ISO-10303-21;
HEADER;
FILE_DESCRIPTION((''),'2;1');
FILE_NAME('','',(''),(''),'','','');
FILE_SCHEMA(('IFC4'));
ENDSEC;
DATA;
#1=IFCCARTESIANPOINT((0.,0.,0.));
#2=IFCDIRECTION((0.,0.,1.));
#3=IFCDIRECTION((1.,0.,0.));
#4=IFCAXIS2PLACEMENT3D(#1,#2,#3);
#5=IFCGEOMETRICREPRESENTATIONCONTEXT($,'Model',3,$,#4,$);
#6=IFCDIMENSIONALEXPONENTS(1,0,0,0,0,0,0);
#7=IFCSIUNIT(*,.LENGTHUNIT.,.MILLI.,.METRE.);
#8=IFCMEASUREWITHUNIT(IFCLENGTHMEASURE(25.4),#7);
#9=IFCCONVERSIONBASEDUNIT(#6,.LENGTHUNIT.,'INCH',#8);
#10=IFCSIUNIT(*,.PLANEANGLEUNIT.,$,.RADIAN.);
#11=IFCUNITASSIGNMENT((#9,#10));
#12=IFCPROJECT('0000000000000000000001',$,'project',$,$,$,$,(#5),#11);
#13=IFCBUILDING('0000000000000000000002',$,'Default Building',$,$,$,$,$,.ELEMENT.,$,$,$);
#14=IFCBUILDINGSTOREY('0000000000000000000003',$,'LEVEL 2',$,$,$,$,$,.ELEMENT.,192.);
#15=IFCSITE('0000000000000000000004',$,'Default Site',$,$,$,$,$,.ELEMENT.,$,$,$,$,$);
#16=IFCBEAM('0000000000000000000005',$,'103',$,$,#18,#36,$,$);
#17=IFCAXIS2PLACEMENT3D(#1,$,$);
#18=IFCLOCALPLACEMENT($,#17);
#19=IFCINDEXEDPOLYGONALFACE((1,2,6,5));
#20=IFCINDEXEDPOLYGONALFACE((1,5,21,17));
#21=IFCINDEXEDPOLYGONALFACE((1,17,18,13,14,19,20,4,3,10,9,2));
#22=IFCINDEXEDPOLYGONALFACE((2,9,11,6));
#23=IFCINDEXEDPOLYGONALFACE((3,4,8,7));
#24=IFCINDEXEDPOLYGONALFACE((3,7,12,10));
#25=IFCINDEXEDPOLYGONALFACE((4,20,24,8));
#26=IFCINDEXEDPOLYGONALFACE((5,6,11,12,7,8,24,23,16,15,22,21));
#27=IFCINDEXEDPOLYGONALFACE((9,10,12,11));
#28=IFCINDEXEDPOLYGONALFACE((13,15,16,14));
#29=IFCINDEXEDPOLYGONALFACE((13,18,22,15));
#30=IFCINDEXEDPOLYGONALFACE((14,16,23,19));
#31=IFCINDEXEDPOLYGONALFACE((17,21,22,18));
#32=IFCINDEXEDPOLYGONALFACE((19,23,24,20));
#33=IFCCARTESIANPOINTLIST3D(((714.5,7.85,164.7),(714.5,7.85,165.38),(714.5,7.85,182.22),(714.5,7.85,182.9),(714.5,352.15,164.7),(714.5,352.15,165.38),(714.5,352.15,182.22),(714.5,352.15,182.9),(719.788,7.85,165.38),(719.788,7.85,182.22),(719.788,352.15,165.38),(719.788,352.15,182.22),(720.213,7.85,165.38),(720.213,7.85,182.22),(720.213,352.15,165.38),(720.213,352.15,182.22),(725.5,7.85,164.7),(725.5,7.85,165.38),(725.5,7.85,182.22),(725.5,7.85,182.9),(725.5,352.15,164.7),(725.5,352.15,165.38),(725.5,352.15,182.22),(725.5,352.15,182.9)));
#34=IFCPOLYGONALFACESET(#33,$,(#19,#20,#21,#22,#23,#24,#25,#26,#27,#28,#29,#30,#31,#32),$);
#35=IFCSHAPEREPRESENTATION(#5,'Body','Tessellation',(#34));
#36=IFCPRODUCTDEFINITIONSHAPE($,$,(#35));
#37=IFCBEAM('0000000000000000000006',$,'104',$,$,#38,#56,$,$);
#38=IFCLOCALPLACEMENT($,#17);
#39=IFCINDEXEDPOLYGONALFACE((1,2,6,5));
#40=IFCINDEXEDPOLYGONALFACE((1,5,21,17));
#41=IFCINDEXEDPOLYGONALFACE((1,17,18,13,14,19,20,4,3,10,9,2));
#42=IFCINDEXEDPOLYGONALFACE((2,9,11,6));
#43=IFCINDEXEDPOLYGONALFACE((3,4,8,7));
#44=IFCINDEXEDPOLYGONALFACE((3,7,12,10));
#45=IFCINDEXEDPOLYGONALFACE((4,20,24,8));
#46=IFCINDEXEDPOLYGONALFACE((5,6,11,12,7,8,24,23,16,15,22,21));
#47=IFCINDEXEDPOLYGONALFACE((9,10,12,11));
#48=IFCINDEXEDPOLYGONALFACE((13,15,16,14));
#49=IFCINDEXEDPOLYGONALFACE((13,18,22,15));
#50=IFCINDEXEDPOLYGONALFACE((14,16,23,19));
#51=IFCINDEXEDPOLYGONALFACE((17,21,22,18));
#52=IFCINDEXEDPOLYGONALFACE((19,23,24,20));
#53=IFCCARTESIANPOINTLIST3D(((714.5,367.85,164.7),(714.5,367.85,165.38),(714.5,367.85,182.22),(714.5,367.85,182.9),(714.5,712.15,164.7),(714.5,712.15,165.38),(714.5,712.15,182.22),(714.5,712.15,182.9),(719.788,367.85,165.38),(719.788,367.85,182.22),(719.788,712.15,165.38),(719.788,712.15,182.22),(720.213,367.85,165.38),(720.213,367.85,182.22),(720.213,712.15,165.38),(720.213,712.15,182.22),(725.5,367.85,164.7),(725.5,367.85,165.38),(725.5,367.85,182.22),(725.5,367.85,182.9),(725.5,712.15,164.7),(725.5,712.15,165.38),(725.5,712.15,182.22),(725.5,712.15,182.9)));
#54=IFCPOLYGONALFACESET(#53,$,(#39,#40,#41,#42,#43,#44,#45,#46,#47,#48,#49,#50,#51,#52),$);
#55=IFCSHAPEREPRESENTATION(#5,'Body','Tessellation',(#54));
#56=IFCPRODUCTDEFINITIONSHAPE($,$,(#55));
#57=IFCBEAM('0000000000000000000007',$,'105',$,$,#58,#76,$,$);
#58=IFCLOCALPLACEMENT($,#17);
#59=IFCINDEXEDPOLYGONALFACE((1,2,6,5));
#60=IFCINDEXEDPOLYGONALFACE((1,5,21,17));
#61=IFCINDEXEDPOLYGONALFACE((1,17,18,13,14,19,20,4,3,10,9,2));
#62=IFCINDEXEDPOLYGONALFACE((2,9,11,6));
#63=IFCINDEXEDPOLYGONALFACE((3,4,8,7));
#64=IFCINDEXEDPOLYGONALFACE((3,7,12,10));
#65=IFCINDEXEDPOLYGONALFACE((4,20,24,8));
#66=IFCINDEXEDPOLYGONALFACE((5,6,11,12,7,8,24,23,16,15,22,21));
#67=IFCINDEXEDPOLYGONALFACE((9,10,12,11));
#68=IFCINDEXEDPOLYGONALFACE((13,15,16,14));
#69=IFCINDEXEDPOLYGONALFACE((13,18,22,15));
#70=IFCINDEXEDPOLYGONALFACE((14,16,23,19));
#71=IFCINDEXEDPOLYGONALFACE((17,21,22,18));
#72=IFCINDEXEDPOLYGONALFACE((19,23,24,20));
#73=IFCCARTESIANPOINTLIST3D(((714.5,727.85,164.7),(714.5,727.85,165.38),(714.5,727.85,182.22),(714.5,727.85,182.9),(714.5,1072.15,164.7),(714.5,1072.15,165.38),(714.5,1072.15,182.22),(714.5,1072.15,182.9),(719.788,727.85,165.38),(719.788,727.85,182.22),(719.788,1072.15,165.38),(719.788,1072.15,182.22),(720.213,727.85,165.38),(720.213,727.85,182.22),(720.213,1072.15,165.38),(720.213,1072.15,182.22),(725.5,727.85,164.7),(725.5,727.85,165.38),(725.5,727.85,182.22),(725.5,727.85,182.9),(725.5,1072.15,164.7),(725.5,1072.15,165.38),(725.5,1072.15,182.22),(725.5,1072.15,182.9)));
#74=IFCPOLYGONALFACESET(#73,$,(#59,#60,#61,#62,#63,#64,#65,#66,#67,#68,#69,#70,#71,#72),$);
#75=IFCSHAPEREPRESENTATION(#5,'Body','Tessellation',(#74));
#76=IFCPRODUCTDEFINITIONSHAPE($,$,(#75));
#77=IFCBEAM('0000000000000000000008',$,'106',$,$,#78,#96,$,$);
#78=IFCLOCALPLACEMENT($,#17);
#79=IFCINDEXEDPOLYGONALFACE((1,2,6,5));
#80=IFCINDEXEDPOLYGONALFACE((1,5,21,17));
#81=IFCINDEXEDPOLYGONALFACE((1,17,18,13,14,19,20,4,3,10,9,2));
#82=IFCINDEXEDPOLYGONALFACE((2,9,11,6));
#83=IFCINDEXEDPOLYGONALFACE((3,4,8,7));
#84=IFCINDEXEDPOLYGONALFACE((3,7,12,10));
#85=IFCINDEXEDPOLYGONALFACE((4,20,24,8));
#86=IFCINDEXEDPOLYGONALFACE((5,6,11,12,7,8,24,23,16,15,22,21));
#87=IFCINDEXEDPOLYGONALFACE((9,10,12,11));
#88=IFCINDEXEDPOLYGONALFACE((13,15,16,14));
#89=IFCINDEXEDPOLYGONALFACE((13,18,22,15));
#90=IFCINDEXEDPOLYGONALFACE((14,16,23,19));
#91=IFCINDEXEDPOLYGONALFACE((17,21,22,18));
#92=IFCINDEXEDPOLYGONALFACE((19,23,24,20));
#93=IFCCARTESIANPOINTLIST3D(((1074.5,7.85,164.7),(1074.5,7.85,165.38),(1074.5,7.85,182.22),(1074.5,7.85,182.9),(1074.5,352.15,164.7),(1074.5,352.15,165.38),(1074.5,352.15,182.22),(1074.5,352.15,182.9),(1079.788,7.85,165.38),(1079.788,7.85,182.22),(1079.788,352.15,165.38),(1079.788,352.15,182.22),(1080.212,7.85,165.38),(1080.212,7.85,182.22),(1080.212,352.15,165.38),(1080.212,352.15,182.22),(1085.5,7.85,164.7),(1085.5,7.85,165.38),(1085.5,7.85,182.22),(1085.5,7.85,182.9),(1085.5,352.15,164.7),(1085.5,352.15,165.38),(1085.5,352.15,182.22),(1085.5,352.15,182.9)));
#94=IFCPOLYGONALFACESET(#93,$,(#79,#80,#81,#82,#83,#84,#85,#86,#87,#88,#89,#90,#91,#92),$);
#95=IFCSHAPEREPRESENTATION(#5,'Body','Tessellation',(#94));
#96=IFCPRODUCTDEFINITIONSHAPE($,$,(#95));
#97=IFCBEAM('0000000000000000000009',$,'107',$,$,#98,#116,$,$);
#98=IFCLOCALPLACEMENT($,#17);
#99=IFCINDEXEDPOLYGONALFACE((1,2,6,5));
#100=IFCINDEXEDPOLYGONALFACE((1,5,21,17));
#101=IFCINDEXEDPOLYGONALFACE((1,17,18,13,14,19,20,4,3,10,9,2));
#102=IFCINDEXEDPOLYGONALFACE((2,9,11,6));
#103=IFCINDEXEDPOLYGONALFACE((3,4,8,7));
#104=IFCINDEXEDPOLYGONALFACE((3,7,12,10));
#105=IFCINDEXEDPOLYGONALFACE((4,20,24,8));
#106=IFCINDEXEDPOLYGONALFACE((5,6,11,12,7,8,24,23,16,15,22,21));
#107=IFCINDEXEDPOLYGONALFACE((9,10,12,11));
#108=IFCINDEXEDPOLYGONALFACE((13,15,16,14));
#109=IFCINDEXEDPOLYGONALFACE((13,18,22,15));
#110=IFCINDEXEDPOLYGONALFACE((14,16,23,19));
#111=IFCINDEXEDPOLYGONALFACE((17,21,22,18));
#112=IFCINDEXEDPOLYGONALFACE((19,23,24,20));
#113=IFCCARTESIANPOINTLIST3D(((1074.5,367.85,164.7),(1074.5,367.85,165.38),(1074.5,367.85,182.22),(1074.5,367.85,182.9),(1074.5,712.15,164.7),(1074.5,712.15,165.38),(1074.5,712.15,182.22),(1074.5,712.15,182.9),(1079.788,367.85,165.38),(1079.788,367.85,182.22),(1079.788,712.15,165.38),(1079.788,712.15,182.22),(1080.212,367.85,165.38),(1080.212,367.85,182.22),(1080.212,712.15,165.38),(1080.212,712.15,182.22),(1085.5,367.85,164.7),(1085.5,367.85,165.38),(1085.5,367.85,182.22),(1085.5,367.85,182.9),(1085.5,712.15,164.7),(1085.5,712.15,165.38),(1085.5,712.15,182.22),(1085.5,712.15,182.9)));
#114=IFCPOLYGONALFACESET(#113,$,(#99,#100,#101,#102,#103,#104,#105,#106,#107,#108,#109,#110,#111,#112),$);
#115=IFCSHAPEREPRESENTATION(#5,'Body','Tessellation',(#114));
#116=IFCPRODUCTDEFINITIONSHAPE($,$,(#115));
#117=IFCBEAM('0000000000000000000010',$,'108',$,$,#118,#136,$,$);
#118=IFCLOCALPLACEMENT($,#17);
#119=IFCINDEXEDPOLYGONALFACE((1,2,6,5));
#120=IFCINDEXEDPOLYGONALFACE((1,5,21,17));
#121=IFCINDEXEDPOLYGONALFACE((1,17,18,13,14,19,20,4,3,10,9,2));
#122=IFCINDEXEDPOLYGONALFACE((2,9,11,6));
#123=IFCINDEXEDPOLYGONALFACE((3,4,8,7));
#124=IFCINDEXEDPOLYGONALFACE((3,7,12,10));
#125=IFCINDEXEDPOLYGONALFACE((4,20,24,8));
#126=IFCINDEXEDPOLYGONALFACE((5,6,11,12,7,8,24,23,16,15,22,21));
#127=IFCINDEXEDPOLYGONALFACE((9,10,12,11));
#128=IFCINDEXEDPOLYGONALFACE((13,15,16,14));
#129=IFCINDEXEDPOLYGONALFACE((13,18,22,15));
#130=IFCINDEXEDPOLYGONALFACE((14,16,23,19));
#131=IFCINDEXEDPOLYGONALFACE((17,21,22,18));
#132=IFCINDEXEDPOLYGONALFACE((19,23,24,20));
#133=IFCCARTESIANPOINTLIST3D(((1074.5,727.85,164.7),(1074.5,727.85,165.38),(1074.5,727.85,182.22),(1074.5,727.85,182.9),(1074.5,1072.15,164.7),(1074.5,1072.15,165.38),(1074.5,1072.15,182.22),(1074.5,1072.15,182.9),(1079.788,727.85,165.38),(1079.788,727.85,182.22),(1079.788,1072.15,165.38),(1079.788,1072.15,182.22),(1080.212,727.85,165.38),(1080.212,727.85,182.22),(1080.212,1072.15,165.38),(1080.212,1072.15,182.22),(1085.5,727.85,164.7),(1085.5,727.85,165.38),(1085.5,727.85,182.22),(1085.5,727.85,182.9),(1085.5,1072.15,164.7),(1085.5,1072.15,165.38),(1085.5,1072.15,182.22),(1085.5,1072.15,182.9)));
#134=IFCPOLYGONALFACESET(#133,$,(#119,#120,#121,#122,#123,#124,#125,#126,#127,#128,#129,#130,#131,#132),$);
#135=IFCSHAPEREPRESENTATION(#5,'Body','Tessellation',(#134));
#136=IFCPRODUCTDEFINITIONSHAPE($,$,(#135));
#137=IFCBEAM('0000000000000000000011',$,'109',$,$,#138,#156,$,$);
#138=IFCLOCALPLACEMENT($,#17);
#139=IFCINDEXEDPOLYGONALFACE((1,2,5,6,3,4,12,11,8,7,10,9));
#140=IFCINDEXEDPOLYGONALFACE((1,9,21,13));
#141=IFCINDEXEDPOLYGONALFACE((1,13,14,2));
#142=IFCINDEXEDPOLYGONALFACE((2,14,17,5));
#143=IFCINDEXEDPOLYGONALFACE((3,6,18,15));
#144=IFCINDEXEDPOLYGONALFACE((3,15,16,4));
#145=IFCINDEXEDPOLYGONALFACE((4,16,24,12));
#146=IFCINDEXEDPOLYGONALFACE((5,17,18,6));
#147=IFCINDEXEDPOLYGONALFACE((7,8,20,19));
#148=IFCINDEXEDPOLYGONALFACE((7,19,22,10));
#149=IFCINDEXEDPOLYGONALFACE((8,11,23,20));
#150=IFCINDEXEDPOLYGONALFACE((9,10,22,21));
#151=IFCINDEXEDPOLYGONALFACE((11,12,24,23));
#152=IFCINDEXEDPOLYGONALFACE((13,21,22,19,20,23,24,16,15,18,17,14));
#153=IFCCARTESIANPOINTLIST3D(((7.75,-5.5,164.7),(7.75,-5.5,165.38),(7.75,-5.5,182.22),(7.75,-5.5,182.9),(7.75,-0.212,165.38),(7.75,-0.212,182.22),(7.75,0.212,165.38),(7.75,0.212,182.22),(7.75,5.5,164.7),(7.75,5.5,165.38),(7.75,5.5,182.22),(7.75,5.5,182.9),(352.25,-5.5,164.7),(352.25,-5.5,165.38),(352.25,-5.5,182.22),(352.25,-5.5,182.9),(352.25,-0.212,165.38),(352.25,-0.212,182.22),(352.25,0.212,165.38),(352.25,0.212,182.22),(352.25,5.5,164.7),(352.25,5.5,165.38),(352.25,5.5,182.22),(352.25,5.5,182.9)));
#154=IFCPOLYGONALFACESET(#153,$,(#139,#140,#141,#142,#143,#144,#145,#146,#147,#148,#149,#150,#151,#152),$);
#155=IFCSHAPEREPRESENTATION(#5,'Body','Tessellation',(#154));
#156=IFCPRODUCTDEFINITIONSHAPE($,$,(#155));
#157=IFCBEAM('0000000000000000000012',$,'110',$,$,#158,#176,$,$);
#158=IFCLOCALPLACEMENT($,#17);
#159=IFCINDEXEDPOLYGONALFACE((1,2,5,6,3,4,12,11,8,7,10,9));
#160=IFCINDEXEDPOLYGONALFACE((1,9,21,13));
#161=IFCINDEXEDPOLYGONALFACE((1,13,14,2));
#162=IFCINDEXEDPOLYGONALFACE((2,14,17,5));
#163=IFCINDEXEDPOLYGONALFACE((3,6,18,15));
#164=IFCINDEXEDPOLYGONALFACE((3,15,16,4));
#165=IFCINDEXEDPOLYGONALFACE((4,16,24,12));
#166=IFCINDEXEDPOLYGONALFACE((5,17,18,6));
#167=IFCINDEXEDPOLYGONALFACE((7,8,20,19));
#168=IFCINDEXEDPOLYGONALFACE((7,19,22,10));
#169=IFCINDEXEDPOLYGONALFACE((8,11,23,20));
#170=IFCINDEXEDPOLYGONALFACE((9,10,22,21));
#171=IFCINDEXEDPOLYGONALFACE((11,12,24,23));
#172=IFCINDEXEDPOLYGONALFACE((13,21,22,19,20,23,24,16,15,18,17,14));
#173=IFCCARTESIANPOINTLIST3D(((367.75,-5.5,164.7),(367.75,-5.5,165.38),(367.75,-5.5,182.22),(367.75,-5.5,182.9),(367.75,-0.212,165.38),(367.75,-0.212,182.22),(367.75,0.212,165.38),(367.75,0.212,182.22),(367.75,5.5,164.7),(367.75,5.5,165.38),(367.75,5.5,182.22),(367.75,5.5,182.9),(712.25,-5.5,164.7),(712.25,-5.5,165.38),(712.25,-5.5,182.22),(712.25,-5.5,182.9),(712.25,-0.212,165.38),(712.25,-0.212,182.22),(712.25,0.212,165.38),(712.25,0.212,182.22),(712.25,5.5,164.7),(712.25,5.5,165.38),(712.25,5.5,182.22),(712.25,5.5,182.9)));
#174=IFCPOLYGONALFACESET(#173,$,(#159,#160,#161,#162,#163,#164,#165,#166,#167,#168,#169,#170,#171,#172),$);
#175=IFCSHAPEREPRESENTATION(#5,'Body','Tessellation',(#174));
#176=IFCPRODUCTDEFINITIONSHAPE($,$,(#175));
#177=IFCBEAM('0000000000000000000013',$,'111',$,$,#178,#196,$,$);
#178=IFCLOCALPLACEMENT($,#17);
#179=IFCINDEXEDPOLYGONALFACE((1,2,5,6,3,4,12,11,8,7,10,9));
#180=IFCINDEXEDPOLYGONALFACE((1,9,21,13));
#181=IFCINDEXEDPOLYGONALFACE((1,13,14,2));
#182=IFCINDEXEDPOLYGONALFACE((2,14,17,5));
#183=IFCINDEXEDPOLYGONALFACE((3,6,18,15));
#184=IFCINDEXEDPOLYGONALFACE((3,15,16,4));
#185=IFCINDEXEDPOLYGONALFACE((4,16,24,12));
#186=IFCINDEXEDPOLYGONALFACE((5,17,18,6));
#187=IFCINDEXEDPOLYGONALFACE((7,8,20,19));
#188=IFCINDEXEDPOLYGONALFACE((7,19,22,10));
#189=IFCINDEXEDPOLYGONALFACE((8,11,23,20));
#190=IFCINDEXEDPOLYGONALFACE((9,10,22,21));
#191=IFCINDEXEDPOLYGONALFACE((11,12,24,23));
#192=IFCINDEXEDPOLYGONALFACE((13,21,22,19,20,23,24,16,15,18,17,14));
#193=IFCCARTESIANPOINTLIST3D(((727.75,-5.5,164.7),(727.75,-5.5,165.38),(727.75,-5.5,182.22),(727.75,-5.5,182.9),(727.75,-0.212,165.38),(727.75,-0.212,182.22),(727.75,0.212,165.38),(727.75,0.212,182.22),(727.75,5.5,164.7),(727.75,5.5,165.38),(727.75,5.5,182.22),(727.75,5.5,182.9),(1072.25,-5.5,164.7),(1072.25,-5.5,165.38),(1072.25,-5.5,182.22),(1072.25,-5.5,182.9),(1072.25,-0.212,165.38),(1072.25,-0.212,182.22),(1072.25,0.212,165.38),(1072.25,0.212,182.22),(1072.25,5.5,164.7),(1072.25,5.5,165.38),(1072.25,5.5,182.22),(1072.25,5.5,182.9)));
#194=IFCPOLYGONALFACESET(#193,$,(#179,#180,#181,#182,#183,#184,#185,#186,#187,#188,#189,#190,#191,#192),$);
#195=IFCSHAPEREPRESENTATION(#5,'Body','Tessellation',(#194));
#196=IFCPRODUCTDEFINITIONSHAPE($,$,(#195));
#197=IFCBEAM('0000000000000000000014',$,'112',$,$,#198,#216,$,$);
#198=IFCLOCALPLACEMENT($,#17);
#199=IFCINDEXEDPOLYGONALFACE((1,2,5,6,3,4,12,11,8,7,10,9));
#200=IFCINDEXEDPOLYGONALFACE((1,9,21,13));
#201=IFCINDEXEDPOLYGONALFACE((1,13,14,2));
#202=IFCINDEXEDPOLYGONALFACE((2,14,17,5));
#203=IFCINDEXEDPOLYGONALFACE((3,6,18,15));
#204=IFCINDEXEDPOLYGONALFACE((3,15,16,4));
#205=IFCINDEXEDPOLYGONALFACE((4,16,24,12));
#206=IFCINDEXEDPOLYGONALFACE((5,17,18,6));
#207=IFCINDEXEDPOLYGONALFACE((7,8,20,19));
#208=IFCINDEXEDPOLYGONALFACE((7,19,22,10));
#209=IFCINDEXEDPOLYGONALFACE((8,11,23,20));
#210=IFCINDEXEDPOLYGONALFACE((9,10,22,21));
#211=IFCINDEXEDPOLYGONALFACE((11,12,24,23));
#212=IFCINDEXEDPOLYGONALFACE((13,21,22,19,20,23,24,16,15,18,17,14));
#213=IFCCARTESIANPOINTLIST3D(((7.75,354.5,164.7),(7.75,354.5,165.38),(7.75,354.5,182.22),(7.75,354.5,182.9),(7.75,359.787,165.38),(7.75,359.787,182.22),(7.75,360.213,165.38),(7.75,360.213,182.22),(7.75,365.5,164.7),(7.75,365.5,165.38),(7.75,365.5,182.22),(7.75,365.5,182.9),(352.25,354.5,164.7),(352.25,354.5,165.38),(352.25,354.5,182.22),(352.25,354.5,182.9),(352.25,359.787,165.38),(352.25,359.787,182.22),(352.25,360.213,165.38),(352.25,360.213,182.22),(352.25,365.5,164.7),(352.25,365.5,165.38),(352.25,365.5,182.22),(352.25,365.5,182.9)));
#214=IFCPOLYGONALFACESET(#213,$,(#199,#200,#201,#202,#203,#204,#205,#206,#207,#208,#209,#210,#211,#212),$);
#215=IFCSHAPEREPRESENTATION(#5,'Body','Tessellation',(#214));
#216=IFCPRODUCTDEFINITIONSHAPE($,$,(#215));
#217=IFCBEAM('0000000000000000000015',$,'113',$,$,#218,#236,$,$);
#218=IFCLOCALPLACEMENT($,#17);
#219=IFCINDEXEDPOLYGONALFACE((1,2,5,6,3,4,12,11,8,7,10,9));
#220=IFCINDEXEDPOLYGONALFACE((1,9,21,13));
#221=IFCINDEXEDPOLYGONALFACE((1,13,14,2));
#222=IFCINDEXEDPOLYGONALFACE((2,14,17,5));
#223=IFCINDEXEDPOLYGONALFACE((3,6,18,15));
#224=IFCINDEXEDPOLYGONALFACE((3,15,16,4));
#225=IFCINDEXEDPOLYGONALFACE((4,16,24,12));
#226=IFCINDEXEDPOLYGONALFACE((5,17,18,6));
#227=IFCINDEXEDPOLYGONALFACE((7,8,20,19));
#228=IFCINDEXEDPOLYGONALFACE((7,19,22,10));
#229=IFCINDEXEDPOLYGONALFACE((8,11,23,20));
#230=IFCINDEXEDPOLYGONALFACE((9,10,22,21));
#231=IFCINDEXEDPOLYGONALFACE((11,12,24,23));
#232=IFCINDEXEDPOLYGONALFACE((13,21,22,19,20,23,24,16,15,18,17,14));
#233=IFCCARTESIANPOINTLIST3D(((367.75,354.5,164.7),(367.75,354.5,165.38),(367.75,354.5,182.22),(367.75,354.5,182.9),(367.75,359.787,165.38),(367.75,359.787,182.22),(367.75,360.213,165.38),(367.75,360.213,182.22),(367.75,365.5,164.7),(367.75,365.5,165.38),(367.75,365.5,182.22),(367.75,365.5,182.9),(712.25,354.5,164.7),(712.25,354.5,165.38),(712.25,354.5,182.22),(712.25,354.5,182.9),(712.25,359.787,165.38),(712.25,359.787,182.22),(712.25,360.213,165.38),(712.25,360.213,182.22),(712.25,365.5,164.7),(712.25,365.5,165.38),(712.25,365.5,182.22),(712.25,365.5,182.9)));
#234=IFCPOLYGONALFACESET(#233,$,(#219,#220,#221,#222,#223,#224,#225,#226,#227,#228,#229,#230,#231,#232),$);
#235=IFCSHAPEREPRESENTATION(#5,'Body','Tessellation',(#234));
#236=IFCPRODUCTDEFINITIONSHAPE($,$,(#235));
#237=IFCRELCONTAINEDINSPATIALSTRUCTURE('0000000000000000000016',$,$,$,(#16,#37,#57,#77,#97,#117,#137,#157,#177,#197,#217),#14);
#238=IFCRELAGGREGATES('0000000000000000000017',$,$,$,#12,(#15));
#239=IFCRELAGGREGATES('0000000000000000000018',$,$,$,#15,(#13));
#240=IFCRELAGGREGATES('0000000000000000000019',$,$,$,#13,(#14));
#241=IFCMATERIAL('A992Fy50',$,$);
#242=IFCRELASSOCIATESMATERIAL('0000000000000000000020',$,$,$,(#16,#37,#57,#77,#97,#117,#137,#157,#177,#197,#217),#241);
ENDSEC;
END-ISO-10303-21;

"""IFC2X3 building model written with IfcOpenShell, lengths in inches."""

from ifc_helpers import new_model, entity, si_unit, converted_unit, frame, origin_with_axes, origin_2d_with_axis, place, context, project, spatial, i_section, transform_2d, derived_profile, extrude, material, element, save


model = new_model("IFC2X3")

# Units and contexts
model_context = context("Model", 3, world=origin_with_axes())
ifc_project = project(units=[converted_unit("LENGTHUNIT", "INCH", entity("IfcLengthMeasure", 25.4), si_unit("LENGTHUNIT", "METRE", prefix="MILLI"), dimensions=[1, 0, 0, 0, 0, 0, 0]), si_unit("PLANEANGLEUNIT", "RADIAN")], contexts=[model_context])

# Site, building, storey
site = spatial("IfcSite", under=ifc_project, Name="Default Site", CompositionType="ELEMENT")
building = spatial("IfcBuilding", under=site, Name="Default Building", CompositionType="ELEMENT")
storey = spatial("IfcBuildingStorey", under=building, Name="LEVEL 2", CompositionType="ELEMENT", Elevation=192.0)

# Shared definitions
ifc_material = material(Name="A992Fy50")

# Beams
for number, where, z_axis, x_axis, name in (
    (1, (720.0, 7.85, 192.0), (0.0, 1.0, 0.0), (-1.0, 0.0, 0.0), "103"),
    (2, (720.0, 367.85, 192.0), (0.0, 1.0, 0.0), (-1.0, 0.0, 0.0), "104"),
    (3, (720.0, 727.85, 192.0), (0.0, 1.0, 0.0), (-1.0, 0.0, 0.0), "105"),
    (4, (1080.0, 7.85, 192.0), (0.0, 1.0, 0.0), (-1.0, 0.0, 0.0), "106"),
    (5, (1080.0, 367.85, 192.0), (0.0, 1.0, 0.0), (-1.0, 0.0, 0.0), "107"),
    (6, (1080.0, 727.85, 192.0), (0.0, 1.0, 0.0), (-1.0, 0.0, 0.0), "108"),
):
    element("IfcBeam", number, at=place(None, frame(where, z_axis=z_axis, x_axis=x_axis)), inside=storey, material=ifc_material, Name=name, context=model_context, shape_type="SweptSolid", body=[
        extrude(derived_profile(i_section(OverallWidth=11.0, OverallDepth=18.2, WebThickness=0.425, FlangeThickness=0.68, at=origin_2d_with_axis()), transform_2d((0.0, -9.1))), origin_with_axes(), (0.0, 0.0, 1.0), 344.3),
    ])
for number, where, z_axis, x_axis, name in (
    (7, (7.75, 0.0, 192.0), (1.0, 0.0, 0.0), (0.0, 1.0, 0.0), "109"),
    (8, (367.75, 0.0, 192.0), (1.0, 0.0, 0.0), (0.0, 1.0, 0.0), "110"),
    (9, (727.75, 0.0, 192.0), (1.0, 0.0, 0.0), (0.0, 1.0, 0.0), "111"),
    (10, (7.75, 360.0, 192.0), (1.0, 0.0, 0.0), (0.0, 1.0, 0.0), "112"),
    (11, (367.75, 360.0, 192.0), (1.0, 0.0, 0.0), (0.0, 1.0, 0.0), "113"),
):
    element("IfcBeam", number, at=place(None, frame(where, z_axis=z_axis, x_axis=x_axis)), inside=storey, material=ifc_material, Name=name, context=model_context, shape_type="SweptSolid", body=[
        extrude(derived_profile(i_section(OverallWidth=11.0, OverallDepth=18.2, WebThickness=0.425, FlangeThickness=0.68, at=origin_2d_with_axis()), transform_2d((0.0, -9.1))), origin_with_axes(), (0.0, 0.0, 1.0), 344.5),
    ])

save(model, "model.ifc")
